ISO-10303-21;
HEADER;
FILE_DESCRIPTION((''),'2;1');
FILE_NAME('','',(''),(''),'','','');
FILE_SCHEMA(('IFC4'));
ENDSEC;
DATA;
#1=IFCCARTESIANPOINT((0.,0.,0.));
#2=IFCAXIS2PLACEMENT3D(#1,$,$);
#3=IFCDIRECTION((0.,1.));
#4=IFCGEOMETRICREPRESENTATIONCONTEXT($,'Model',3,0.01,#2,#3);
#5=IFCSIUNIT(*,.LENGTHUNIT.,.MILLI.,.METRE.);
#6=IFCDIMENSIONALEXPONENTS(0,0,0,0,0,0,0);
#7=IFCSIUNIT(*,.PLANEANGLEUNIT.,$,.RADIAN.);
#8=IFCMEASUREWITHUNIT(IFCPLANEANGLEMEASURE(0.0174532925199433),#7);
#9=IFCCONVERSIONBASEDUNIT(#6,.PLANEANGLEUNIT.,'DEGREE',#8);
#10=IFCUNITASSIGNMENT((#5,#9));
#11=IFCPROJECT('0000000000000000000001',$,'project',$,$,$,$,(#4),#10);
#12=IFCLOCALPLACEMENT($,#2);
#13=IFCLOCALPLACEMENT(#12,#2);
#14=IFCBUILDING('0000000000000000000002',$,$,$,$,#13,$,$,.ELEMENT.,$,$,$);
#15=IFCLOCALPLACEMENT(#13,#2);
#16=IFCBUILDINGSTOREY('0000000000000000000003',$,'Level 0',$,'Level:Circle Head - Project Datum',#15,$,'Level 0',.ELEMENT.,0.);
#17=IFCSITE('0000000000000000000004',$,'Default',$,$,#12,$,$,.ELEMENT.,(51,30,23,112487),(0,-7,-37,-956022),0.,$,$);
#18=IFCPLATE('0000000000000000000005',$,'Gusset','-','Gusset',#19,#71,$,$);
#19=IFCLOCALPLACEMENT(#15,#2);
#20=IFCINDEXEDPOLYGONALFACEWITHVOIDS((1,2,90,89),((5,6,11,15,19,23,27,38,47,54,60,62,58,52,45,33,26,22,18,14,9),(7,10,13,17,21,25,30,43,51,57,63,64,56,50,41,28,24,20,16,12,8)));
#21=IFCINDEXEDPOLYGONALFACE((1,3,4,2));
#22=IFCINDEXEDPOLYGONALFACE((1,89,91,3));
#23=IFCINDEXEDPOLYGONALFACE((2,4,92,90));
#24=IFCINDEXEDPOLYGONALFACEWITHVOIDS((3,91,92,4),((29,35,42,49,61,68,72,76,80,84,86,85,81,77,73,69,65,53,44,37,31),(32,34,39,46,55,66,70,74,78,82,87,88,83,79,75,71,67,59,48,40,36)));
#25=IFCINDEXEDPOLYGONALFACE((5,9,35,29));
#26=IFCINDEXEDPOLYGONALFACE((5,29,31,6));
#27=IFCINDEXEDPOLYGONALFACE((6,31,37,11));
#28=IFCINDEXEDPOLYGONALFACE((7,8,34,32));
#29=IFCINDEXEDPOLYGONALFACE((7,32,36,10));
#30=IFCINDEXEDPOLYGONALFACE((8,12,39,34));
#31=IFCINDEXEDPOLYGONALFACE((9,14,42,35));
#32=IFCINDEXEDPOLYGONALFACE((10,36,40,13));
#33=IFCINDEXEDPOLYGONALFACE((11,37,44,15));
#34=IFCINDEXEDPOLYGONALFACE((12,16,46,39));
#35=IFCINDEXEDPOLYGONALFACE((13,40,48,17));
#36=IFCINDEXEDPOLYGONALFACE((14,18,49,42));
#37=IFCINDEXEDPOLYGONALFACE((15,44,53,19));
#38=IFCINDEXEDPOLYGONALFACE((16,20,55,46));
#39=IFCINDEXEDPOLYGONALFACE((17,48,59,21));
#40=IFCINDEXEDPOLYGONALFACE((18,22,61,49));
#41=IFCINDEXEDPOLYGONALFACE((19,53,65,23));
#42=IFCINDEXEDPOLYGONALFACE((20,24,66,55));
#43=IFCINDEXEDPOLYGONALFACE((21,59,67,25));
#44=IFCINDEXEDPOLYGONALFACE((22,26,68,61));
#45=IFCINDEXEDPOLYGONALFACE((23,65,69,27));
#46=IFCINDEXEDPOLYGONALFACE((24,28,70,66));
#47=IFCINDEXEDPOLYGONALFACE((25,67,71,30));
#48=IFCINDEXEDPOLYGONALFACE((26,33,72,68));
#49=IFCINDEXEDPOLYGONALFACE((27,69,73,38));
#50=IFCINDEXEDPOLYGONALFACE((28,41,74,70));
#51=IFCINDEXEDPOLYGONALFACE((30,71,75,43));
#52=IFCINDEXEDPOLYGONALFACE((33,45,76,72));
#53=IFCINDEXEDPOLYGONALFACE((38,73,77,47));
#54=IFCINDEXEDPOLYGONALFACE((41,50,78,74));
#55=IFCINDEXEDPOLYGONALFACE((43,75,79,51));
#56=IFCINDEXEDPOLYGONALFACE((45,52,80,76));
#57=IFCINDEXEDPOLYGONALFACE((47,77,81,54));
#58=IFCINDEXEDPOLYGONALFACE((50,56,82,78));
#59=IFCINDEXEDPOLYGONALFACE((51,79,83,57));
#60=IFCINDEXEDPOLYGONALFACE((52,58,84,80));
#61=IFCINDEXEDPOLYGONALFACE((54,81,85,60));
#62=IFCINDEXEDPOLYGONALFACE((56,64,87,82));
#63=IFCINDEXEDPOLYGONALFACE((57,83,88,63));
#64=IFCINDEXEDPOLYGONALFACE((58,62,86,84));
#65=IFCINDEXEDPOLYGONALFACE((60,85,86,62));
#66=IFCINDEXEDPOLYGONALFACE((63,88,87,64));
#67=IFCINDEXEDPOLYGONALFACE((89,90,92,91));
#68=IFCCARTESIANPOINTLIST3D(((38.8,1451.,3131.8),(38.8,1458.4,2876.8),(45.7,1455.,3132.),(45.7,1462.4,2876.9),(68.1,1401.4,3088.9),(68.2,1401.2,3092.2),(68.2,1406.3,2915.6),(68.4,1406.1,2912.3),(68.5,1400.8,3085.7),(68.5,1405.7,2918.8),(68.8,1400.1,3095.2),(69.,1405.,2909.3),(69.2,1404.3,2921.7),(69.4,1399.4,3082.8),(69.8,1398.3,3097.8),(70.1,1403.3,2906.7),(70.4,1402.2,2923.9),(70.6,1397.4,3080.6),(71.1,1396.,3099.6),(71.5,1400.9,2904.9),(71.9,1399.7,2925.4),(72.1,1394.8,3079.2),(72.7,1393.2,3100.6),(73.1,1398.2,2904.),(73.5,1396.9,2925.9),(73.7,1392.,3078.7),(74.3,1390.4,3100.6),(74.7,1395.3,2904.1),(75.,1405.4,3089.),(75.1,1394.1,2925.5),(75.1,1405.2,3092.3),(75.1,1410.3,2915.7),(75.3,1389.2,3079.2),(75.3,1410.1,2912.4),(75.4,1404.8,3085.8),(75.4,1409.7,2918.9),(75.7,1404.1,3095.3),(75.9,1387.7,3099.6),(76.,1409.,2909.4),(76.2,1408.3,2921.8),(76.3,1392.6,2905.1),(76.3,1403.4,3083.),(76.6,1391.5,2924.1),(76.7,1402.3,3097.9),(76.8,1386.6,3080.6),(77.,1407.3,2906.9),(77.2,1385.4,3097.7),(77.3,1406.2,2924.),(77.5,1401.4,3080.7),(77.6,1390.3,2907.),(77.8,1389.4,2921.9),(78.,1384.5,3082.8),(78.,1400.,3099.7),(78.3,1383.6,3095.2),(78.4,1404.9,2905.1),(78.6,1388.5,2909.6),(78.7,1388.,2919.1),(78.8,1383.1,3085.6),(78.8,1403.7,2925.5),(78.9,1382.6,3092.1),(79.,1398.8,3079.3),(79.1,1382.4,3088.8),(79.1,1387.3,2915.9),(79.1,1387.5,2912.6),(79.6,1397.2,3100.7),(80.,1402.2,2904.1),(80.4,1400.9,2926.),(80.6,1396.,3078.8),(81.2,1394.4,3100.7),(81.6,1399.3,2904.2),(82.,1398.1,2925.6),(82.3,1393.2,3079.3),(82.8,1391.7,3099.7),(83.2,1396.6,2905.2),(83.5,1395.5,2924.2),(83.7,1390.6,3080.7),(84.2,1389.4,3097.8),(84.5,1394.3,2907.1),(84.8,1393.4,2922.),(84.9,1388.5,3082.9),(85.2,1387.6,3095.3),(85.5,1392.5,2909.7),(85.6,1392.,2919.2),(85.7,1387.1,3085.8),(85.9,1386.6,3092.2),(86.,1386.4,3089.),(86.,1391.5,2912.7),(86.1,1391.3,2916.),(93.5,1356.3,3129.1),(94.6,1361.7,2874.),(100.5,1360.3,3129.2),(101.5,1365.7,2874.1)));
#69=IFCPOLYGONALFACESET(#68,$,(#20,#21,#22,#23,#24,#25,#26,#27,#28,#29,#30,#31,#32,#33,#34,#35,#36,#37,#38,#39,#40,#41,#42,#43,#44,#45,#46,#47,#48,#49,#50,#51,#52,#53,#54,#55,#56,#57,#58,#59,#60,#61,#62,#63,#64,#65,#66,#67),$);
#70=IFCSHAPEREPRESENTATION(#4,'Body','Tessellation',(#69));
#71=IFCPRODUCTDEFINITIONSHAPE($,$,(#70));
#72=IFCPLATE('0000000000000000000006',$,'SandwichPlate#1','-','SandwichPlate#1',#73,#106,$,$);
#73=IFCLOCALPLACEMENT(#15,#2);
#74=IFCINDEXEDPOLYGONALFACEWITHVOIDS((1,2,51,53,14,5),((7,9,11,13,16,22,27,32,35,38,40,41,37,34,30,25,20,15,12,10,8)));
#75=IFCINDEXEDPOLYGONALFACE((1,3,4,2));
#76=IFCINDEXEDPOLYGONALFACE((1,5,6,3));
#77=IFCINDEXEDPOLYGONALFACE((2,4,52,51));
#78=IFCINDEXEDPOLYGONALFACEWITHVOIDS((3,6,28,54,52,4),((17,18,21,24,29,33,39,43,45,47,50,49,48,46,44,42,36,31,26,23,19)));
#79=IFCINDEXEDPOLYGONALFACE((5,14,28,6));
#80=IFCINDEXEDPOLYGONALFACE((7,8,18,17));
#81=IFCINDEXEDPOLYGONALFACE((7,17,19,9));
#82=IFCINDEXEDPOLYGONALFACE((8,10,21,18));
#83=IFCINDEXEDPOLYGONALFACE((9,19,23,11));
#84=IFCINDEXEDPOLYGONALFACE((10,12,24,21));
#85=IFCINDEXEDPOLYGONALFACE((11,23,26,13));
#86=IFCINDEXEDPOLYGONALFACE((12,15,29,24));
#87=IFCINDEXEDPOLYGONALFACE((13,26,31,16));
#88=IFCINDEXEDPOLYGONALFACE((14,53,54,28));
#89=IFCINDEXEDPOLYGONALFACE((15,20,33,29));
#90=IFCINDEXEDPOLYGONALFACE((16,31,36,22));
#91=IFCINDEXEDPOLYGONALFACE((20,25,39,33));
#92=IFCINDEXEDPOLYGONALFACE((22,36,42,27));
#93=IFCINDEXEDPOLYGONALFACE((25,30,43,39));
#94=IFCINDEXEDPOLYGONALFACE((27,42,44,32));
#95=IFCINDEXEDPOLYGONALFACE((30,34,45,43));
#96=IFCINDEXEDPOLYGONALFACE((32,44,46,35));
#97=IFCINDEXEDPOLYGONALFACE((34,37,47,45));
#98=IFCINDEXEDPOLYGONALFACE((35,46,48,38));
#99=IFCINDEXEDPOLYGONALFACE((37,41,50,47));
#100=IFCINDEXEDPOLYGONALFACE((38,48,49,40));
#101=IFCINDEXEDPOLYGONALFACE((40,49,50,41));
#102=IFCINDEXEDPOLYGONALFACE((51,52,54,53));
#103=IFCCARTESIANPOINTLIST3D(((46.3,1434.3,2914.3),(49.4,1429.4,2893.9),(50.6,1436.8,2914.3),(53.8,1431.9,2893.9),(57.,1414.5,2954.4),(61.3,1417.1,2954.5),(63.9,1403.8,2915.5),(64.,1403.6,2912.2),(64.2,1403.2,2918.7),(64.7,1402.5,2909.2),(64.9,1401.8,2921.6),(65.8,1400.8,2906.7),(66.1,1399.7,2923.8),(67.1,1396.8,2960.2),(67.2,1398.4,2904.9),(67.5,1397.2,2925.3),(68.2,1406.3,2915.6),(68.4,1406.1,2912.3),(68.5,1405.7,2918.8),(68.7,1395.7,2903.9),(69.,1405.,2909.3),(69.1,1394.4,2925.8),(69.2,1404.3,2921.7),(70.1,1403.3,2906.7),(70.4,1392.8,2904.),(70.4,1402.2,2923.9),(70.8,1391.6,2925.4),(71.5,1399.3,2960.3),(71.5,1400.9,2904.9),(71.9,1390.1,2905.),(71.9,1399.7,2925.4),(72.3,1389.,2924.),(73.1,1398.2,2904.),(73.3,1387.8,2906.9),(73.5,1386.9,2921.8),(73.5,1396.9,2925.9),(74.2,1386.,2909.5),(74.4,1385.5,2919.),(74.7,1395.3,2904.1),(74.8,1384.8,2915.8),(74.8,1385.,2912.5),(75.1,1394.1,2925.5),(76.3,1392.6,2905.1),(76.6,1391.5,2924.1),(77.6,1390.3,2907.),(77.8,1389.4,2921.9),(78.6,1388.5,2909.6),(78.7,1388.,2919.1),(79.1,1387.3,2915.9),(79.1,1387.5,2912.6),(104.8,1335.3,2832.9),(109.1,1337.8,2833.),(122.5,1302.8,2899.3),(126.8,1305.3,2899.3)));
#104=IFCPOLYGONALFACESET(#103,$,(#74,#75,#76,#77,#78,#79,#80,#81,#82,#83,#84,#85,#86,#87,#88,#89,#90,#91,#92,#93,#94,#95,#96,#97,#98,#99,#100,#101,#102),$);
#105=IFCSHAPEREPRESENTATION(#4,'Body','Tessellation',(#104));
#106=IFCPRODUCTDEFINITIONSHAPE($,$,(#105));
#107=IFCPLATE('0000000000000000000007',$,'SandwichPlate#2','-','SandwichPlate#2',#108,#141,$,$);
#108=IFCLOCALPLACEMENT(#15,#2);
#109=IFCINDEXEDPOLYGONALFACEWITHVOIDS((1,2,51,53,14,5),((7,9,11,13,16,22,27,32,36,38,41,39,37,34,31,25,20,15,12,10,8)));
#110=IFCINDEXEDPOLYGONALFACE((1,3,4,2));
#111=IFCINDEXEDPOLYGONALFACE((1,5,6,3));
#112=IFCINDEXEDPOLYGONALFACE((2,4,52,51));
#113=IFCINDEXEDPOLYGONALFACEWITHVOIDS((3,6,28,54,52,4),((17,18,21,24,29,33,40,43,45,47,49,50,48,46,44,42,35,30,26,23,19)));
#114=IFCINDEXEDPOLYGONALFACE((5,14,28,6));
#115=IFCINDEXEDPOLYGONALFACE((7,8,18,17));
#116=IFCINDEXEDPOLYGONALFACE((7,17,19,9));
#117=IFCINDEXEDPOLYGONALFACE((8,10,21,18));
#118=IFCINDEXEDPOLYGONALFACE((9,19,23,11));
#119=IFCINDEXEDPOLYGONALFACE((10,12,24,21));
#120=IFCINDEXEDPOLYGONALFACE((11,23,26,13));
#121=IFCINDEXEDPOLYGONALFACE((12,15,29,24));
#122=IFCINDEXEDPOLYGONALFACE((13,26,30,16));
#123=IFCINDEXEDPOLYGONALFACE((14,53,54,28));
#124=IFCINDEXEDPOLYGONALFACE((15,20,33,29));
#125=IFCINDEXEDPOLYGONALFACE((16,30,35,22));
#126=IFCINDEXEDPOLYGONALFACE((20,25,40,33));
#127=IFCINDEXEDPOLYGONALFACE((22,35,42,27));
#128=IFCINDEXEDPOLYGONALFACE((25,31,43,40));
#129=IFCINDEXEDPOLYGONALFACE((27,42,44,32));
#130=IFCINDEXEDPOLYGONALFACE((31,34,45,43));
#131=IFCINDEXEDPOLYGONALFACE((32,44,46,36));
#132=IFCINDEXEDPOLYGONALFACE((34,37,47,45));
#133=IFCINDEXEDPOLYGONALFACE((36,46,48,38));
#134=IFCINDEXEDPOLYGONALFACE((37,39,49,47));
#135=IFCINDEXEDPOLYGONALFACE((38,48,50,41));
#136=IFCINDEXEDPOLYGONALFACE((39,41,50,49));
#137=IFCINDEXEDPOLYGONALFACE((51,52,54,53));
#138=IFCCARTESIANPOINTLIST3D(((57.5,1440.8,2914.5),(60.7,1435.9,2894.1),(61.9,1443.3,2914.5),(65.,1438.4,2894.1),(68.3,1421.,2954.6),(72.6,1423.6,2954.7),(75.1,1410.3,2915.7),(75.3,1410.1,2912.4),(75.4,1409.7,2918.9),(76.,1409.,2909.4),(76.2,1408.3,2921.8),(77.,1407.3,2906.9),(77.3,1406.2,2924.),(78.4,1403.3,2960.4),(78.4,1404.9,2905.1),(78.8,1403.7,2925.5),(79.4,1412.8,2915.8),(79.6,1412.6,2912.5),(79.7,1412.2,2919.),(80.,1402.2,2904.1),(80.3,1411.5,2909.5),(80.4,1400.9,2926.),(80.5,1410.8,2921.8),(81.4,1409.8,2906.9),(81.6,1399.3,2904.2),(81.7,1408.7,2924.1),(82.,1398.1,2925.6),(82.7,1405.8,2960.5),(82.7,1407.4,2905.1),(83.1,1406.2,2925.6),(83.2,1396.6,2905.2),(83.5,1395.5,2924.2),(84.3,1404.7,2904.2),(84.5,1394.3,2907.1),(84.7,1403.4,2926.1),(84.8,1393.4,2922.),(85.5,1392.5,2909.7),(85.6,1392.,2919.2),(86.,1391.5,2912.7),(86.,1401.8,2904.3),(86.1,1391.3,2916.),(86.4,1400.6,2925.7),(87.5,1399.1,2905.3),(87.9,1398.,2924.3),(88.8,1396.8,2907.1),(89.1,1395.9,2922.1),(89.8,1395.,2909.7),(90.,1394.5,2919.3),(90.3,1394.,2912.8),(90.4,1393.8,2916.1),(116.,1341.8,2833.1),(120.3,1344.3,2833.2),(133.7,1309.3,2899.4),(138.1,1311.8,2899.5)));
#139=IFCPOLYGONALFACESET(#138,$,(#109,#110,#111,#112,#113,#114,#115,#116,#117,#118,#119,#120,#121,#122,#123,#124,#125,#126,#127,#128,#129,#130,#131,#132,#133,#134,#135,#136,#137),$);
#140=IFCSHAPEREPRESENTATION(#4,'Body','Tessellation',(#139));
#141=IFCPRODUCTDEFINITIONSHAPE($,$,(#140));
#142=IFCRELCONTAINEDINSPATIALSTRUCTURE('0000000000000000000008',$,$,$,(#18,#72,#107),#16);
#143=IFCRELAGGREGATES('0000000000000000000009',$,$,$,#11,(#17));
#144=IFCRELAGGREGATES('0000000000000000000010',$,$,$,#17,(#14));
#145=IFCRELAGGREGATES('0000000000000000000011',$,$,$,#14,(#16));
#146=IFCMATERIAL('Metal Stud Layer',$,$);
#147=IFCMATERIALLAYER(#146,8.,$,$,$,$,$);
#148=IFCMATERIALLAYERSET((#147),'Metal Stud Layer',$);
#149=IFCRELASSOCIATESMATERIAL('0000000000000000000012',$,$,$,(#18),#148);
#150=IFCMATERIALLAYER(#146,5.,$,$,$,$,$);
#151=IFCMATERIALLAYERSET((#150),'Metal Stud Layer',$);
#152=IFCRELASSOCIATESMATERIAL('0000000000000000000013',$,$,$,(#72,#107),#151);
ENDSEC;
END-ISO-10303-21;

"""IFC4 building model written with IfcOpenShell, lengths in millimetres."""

from ifc_helpers import new_model, entity, si_unit, converted_unit, direction, frame, origin, origin_with_axes, origin_2d_with_axis, place, context, project, spatial, polyline, circle, outline, extrude, material, layer, layer_set, element, save


model = new_model("IFC4")

# Units and contexts
model_context = context("Model", 3, precision=0.01, world=origin(), true_north=direction((0.0, 1.0)))
ifc_project = project(units=[si_unit("LENGTHUNIT", "METRE", prefix="MILLI"), converted_unit("PLANEANGLEUNIT", "DEGREE", entity("IfcPlaneAngleMeasure", 0.0174532925199433), si_unit("PLANEANGLEUNIT", "RADIAN"), dimensions=[0, 0, 0, 0, 0, 0, 0])], contexts=[model_context])

# Site, building, storey
site_placement = place(None, origin())
site = spatial("IfcSite", under=ifc_project, at=site_placement, Name="Default", CompositionType="ELEMENT", RefLatitude=(51, 30, 23, 112487), RefLongitude=(0, -7, -37, -956022), RefElevation=0.0)
building_placement = place(site_placement, origin())
building = spatial("IfcBuilding", under=site, at=building_placement, CompositionType="ELEMENT")
storey_placement = place(building_placement, origin())
storey = spatial("IfcBuildingStorey", under=building, at=storey_placement, Name="Level 0", ObjectType="Level:Circle Head - Project Datum", LongName="Level 0", CompositionType="ELEMENT", Elevation=0.0)

# Plates, openings
ifc_material_1 = material(Name="Metal Stud Layer")
ifc_layer_1 = layer(ifc_material_1, 8.0)
ifc_layer_set_1 = layer_set([ifc_layer_1], Name="Metal Stud Layer")
plate_1_placement = place(storey_placement, frame((46.7, 1453.3, 3131.9), z_axis=(-0.865935, -0.499948, -0.014432), x_axis=(0.0, 0.028855, -0.999584)))
plate_1 = element("IfcPlate", 1, at=plate_1_placement, inside=storey, material=ifc_layer_set_1, Name="Gusset", Description="-", ObjectType="Gusset", context=model_context, shape_type="SweptSolid", body=[
    extrude(outline(polyline([(0.0, -2.0), (255.1, -2.0), (255.1, 109.6), (0.0, 107.5), (0.0, -2.0)])), origin_with_axes(), (0.0, 0.0, 1.0), 8.0),
])
opening_1_placement = place(plate_1_placement, frame((40.4, 67.6, 8.5), z_axis=(0.0, 0.0, -1.0), x_axis=(-0.519479, 0.854483, 0.0)))
element("IfcOpeningElement", 2, at=opening_1_placement, cuts=plate_1, ObjectType="Opening", context=model_context, shape_type="SweptSolid", body=[
    extrude(circle(Radius=11.0, at=origin_2d_with_axis()), origin(), (0.0, 0.0, 1.0), 9.0),
])
opening_2_placement = place(plate_1_placement, frame((215.3, 67.8, 8.5), z_axis=(0.0, 0.0, -1.0), x_axis=(0.465705, 0.88494, 0.0)))
element("IfcOpeningElement", 3, at=opening_2_placement, cuts=plate_1, ObjectType="Opening", context=model_context, shape_type="SweptSolid", body=[
    extrude(circle(Radius=11.0, at=origin_2d_with_axis()), origin(), (0.0, 0.0, 1.0), 9.0),
])
ifc_layer_2 = layer(ifc_material_1, 5.0)
ifc_layer_set_2 = layer_set([ifc_layer_2], Name="Metal Stud Layer")
plate_2_placement = place(storey_placement, frame((42.8, 1440.7, 2901.2), z_axis=(0.865935, 0.499948, 0.014432), x_axis=(0.232925, -0.428638, 0.872935)))
plate_2 = element("IfcPlate", 4, at=plate_2_placement, inside=storey, material=ifc_layer_set_2, Name="SandwichPlate#1", Description="-", ObjectType="SandwichPlate#1", context=model_context, shape_type="SweptSolid", body=[
    extrude(outline(polyline([(0.0, 0.0), (76.0, 0.0), (76.0, 140.0), (0.0, 140.0), (0.0, 0.0)])), origin_with_axes(), (0.0, 0.0, 1.0), 5.0),
])
opening_3_placement = place(plate_2_placement, frame((0.0, 0.0, 0.0), z_axis=(0.0, 0.0, 1.0), x_axis=(1.0, 0.0, 0.0)))
element("IfcOpeningElement", 5, at=opening_3_placement, cuts=plate_2, ObjectType="Opening", context=model_context, shape_type="SweptSolid", body=[
    extrude(outline(polyline([(0.0, 0.0), (15.0, 0.0), (0.0, 15.0), (0.0, 0.0)])), origin(), (0.0, 0.0, 1.0), 5.0),
])
opening_4_placement = place(plate_2_placement, frame((0.0, 0.0, 0.0), z_axis=(0.0, 0.0, 1.0), x_axis=(1.0, 0.0, 0.0)))
element("IfcOpeningElement", 6, at=opening_4_placement, cuts=plate_2, ObjectType="Opening", context=model_context, shape_type="SweptSolid", body=[
    extrude(outline(polyline([(76.0, 0.0), (76.0, 15.0), (61.0, 0.0), (76.0, 0.0)])), origin(), (0.0, 0.0, 1.0), 5.0),
])
opening_5_placement = place(plate_2_placement, frame((38.0, 40.0, -0.5), z_axis=(0.0, 0.0, 1.0), x_axis=(0.0, 1.0, 0.0)))
element("IfcOpeningElement", 7, at=opening_5_placement, cuts=plate_2, ObjectType="Opening", context=model_context, shape_type="SweptSolid", body=[
    extrude(circle(Radius=11.0, at=origin_2d_with_axis()), origin(), (0.0, 0.0, 1.0), 6.0),
])
plate_3_placement = place(storey_placement, frame((54.1, 1447.2, 2901.4), z_axis=(0.865935, 0.499948, 0.014432), x_axis=(0.232925, -0.428638, 0.872935)))
plate_3 = element("IfcPlate", 8, at=plate_3_placement, inside=storey, material=ifc_layer_set_2, Name="SandwichPlate#2", Description="-", ObjectType="SandwichPlate#2", context=model_context, shape_type="SweptSolid", body=[
    extrude(outline(polyline([(0.0, 0.0), (76.0, 0.0), (76.0, 140.0), (0.0, 140.0), (0.0, 0.0)])), origin_with_axes(), (0.0, 0.0, 1.0), 5.0),
])
opening_6_placement = place(plate_3_placement, frame((0.0, 0.0, 0.0), z_axis=(0.0, 0.0, 1.0), x_axis=(1.0, 0.0, 0.0)))
element("IfcOpeningElement", 9, at=opening_6_placement, cuts=plate_3, ObjectType="Opening", context=model_context, shape_type="SweptSolid", body=[
    extrude(outline(polyline([(0.0, 0.0), (15.0, 0.0), (0.0, 15.0), (0.0, 0.0)])), origin(), (0.0, 0.0, 1.0), 5.0),
])
opening_7_placement = place(plate_3_placement, frame((0.0, 0.0, 0.0), z_axis=(0.0, 0.0, 1.0), x_axis=(1.0, 0.0, 0.0)))
element("IfcOpeningElement", 10, at=opening_7_placement, cuts=plate_3, ObjectType="Opening", context=model_context, shape_type="SweptSolid", body=[
    extrude(outline(polyline([(76.0, 0.0), (76.0, 15.0), (61.0, 0.0), (76.0, 0.0)])), origin(), (0.0, 0.0, 1.0), 5.0),
])
opening_8_placement = place(plate_3_placement, frame((38.0, 40.0, -0.5), z_axis=(0.0, 0.0, 1.0), x_axis=(0.0, 1.0, 0.0)))
element("IfcOpeningElement", 11, at=opening_8_placement, cuts=plate_3, ObjectType="Opening", context=model_context, shape_type="SweptSolid", body=[
    extrude(circle(Radius=11.0, at=origin_2d_with_axis()), origin(), (0.0, 0.0, 1.0), 6.0),
])

save(model, "model.ifc")
